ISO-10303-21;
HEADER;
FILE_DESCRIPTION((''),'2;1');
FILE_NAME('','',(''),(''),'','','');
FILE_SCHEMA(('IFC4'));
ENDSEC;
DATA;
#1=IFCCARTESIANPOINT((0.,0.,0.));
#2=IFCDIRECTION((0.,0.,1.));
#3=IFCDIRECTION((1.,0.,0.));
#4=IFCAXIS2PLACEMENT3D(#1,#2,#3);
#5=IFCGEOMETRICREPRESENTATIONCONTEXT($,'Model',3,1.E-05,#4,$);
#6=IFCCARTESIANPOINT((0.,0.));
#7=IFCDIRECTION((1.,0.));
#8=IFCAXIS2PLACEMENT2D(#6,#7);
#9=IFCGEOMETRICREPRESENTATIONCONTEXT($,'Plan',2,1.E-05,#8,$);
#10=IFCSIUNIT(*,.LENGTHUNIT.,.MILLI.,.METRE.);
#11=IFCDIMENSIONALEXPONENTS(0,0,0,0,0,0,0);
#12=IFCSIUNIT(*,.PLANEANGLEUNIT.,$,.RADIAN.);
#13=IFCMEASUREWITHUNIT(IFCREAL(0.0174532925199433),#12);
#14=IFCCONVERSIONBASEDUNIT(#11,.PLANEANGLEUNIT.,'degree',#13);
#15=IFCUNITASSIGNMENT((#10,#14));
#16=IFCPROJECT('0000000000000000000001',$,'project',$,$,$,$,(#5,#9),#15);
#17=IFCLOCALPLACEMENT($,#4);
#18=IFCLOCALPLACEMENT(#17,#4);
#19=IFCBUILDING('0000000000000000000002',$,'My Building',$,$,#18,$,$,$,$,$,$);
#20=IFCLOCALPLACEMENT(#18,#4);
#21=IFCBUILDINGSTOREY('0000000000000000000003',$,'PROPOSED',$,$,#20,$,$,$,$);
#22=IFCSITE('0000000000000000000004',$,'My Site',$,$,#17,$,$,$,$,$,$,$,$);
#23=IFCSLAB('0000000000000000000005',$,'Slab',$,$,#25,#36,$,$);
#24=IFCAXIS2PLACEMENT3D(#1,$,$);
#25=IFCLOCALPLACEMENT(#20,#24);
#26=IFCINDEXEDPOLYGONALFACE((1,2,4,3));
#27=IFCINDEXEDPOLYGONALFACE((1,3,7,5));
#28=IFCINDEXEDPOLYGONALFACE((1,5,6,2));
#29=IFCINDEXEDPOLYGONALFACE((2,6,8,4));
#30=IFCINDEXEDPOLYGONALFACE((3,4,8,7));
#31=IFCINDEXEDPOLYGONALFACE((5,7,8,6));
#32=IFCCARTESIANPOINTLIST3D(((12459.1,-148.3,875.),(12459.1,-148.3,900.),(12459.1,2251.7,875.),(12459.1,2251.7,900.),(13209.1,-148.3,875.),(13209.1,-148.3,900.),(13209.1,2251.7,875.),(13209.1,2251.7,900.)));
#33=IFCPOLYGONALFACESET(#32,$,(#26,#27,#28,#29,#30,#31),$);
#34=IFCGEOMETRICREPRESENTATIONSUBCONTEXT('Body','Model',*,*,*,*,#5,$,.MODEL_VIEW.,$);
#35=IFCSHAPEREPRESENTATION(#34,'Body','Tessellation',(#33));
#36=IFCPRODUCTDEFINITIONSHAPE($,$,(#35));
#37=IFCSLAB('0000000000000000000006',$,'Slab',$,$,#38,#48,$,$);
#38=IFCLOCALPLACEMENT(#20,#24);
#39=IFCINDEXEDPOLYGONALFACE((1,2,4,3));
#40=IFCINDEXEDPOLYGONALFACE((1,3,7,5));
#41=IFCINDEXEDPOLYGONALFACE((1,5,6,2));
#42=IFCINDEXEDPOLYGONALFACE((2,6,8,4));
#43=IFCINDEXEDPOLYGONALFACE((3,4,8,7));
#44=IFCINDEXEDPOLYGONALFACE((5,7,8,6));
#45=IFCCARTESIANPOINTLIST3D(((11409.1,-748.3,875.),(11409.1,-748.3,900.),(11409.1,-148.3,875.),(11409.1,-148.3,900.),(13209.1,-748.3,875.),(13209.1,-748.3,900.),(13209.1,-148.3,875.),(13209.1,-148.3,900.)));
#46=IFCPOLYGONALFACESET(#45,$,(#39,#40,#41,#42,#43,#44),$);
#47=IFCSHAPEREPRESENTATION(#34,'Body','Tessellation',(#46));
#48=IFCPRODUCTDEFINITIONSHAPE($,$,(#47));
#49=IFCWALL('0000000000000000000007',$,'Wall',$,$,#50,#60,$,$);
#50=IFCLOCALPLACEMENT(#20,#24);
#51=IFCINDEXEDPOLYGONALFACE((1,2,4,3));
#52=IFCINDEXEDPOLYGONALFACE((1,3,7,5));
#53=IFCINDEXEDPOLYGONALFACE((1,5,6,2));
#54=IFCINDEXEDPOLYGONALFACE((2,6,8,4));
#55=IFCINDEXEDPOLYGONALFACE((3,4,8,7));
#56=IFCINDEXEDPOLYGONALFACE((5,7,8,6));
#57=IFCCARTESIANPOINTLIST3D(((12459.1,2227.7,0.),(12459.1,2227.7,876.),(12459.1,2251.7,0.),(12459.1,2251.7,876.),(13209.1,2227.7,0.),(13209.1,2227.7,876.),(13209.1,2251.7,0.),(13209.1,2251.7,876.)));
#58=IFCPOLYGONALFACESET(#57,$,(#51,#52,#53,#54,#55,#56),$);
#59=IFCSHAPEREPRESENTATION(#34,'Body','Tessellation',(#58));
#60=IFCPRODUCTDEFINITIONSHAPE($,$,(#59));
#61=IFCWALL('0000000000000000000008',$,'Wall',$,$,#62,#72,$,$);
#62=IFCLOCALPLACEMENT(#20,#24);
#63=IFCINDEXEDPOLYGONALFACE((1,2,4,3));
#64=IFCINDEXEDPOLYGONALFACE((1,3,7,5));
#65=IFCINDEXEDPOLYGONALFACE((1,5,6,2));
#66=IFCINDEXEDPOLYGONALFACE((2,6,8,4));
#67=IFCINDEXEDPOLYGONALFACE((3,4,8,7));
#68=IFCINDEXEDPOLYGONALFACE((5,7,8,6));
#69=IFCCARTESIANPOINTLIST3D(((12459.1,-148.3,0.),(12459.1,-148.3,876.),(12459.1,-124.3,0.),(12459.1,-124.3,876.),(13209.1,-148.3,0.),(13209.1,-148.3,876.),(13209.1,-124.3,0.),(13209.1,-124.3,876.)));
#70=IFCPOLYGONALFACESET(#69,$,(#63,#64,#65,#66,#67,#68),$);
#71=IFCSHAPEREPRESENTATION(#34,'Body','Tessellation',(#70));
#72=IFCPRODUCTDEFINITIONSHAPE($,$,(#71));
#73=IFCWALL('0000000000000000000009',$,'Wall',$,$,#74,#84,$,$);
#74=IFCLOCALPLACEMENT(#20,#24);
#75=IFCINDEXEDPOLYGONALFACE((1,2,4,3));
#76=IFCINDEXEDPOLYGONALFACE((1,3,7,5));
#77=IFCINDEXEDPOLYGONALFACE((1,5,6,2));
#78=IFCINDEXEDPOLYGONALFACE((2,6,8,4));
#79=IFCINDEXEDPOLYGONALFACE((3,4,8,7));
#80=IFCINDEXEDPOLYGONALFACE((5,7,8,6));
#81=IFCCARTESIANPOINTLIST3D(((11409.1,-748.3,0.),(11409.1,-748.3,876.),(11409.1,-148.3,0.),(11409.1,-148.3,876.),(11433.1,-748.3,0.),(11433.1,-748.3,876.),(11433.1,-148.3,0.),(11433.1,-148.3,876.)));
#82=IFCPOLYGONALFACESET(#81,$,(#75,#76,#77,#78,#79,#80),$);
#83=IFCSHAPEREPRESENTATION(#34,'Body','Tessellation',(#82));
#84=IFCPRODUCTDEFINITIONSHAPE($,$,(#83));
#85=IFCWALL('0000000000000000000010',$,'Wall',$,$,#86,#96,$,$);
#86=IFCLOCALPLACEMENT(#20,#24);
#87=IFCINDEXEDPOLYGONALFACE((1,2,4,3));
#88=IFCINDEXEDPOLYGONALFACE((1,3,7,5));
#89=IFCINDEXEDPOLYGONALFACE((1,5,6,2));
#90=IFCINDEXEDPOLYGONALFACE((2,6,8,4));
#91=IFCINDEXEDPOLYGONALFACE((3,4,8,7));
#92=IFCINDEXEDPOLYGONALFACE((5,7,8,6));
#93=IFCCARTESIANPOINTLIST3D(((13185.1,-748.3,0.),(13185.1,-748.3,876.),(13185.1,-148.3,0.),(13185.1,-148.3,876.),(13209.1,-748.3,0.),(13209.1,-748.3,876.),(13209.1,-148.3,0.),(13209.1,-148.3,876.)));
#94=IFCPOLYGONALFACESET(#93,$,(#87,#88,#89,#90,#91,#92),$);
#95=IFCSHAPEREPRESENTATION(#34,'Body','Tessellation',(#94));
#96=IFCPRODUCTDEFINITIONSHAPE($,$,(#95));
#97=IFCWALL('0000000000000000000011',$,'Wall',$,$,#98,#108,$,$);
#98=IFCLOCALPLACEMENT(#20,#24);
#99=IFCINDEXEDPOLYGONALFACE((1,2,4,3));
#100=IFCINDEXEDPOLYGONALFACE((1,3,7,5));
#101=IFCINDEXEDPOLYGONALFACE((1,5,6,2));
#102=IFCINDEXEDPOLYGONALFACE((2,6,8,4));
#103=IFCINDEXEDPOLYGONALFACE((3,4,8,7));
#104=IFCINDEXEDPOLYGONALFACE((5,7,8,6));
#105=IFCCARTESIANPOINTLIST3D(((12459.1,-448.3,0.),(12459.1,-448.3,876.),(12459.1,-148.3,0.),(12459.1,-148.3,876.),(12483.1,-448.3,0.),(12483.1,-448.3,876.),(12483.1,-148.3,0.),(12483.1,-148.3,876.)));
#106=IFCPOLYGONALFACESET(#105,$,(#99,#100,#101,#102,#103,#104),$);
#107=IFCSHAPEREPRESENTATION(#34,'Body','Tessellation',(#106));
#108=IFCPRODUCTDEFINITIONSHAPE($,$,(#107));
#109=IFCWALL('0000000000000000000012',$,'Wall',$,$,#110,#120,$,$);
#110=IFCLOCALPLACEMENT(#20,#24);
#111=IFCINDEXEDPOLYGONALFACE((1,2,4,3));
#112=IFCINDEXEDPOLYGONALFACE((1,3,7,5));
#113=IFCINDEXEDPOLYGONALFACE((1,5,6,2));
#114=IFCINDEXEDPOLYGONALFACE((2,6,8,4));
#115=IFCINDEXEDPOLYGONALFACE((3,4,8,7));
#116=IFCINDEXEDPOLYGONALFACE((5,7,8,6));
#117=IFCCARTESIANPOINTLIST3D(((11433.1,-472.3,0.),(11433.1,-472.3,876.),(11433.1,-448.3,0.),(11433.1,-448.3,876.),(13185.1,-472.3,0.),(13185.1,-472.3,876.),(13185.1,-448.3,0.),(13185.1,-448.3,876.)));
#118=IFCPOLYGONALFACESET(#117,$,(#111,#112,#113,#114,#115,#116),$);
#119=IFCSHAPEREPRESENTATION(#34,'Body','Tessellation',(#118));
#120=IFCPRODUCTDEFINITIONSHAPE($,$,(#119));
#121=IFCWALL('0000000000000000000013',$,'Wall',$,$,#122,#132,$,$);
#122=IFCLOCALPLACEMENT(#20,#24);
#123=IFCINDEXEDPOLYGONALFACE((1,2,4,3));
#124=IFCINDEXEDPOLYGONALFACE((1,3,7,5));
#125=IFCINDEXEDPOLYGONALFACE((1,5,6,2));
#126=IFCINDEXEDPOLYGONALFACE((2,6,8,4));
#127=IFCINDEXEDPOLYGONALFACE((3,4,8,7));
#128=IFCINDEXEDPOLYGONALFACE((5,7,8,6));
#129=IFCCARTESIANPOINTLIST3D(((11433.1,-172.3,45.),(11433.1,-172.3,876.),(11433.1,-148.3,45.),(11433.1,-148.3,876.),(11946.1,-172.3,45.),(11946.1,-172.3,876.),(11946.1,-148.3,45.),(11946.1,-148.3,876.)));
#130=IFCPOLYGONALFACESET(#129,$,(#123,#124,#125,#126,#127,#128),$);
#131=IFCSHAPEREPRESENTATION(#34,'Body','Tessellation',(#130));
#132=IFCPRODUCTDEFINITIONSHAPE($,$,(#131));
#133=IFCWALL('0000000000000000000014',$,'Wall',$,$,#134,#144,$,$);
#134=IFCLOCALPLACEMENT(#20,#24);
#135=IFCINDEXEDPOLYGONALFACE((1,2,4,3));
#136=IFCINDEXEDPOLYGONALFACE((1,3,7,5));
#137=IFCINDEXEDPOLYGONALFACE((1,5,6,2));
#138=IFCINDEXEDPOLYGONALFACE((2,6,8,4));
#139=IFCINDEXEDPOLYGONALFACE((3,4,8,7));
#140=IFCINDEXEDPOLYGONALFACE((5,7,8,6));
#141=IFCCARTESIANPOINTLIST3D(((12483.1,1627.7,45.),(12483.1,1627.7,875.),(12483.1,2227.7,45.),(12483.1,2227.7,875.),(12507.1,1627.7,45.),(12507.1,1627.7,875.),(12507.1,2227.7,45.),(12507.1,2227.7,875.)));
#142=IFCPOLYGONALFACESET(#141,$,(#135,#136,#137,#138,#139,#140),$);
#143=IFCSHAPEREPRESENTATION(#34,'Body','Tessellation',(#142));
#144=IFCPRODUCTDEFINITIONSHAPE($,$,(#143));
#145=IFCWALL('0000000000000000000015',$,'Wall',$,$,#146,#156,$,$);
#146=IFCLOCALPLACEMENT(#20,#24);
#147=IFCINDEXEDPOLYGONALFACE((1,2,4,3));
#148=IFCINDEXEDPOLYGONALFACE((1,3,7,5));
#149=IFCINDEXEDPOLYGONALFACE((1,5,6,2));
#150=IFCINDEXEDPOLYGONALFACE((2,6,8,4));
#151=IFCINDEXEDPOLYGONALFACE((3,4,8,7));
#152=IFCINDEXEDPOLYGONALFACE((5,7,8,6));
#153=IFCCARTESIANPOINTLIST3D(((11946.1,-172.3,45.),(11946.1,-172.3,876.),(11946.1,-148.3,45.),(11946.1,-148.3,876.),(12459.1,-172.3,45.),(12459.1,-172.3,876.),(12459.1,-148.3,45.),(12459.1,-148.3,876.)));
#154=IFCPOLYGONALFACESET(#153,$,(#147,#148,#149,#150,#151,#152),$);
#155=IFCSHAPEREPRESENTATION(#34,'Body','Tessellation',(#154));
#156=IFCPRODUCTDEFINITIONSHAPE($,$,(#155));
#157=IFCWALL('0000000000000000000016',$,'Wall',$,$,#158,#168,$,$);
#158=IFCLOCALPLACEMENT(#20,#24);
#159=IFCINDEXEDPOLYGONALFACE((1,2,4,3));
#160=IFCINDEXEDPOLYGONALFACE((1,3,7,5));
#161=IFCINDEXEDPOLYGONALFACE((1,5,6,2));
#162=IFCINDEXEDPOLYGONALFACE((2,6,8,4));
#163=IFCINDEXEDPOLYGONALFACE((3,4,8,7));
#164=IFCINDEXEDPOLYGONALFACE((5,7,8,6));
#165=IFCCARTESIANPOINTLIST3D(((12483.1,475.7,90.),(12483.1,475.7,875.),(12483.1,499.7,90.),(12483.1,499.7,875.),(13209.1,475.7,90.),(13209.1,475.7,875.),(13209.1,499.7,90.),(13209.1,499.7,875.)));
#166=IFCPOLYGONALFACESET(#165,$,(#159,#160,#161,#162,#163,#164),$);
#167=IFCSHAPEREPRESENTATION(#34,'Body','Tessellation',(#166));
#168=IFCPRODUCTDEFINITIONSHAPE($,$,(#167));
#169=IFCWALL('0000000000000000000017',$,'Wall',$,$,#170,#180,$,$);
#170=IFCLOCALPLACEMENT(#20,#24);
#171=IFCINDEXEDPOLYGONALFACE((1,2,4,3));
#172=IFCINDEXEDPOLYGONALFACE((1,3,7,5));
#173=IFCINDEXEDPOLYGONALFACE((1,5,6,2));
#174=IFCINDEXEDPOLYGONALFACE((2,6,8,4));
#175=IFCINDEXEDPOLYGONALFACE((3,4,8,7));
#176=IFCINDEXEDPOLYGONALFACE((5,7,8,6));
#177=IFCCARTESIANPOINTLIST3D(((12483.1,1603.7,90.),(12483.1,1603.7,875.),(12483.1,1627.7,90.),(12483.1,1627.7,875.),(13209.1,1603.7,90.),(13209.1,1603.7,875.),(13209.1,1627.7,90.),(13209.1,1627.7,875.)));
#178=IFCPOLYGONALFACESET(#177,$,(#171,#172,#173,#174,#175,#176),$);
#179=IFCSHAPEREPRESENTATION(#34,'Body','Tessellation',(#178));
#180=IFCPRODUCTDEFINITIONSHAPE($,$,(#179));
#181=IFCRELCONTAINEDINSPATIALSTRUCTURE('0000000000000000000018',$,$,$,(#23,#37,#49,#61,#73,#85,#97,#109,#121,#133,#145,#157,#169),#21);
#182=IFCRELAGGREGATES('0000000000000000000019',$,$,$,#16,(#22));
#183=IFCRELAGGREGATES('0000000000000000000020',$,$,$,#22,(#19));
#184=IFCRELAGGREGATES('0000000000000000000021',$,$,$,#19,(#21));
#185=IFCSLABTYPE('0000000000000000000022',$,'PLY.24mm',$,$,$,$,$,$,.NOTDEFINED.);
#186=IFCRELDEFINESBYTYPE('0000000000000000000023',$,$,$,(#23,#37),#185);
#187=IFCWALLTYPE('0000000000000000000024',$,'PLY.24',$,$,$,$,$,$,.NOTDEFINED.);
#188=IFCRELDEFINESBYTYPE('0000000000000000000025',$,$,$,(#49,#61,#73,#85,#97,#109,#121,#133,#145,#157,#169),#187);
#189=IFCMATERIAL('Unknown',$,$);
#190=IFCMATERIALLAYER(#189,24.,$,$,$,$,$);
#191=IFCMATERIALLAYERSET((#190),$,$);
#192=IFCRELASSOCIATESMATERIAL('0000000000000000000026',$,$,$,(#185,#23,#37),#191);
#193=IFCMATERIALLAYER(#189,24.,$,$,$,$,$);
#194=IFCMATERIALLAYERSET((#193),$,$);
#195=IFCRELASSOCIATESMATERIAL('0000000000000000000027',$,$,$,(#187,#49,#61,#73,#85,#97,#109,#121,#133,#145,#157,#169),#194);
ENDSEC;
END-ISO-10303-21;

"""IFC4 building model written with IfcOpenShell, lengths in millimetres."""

from ifc_helpers import new_model, entity, si_unit, converted_unit, frame, origin_with_axes, origin_2d_with_axis, place, context, subcontext, project, spatial, line, indexed_curve, outline, extrude, material, layer, layer_set, layer_usage, type_object, element, save


model = new_model("IFC4")

# Units and contexts
model_context = context("Model", 3, precision=1e-05, world=origin_with_axes())
plan_context = context("Plan", 2, precision=1e-05, world=origin_2d_with_axis())
body_context = subcontext(model_context, "Body", "Model", "MODEL_VIEW")
ifc_project = project(units=[si_unit("LENGTHUNIT", "METRE", prefix="MILLI"), converted_unit("PLANEANGLEUNIT", "degree", entity("IfcReal", 0.0174532925199433), si_unit("PLANEANGLEUNIT", "RADIAN"), dimensions=[0, 0, 0, 0, 0, 0, 0])], contexts=[model_context, plan_context])

# Site, building, storey
site_placement = place(None, origin_with_axes())
site = spatial("IfcSite", under=ifc_project, at=site_placement, Name="My Site")
building_placement = place(site_placement, origin_with_axes())
building = spatial("IfcBuilding", under=site, at=building_placement, Name="My Building")
storey_placement = place(building_placement, origin_with_axes())
storey = spatial("IfcBuildingStorey", under=building, at=storey_placement, Name="PROPOSED")

# Slabs
ifc_material = material(Name="Unknown")
ifc_layer_1 = layer(ifc_material, 24.0)
ifc_layer_set_1 = layer_set([ifc_layer_1])
ifc_layer_usage_1 = layer_usage(ifc_layer_set_1, "AXIS3", "POSITIVE", 0.0)
slab_type = type_object("IfcSlabType", Name="PLY.24mm", PredefinedType="NOTDEFINED", material=ifc_layer_set_1)
slab_1_placement = place(storey_placement, frame((12459.1, -148.3, 875.0), z_axis=(0.0, 0.0, 1.0), x_axis=(1.0, 0.0, 0.0)))
element("IfcSlab", 1, at=slab_1_placement, inside=storey, type_object=slab_type, material=ifc_layer_usage_1, Name="Slab", context=body_context, shape_type="SweptSolid", body=[
    extrude(outline(indexed_curve([(750.0, 2400.0), (750.0, 0.0), (0.0, 0.0), (0.0, 2400.0)], segments=[line(4, 1), line(1, 2), line(2, 3), line(3, 4)], self_intersect=False)), None, (0.0, 0.0, 1.0), 25.0),
])
ifc_layer_usage_2 = layer_usage(ifc_layer_set_1, "AXIS3", "POSITIVE", 0.0)
slab_2_placement = place(storey_placement, frame((11409.1, -148.3, 875.0), z_axis=(0.0, 0.0, 1.0), x_axis=(0.0, -1.0, 0.0)))
element("IfcSlab", 2, at=slab_2_placement, inside=storey, type_object=slab_type, material=ifc_layer_usage_2, Name="Slab", context=body_context, shape_type="SweptSolid", body=[
    extrude(outline(indexed_curve([(600.0, 0.0), (600.0, 1800.0), (0.0, 1800.0), (0.0, 0.0)], segments=[line(3, 2), line(2, 1), line(1, 4), line(4, 3)], self_intersect=False)), None, (0.0, 0.0, 1.0), 25.0),
])

# Walls
ifc_layer_2 = layer(ifc_material, 24.0)
ifc_layer_set_2 = layer_set([ifc_layer_2])
ifc_layer_usage_3 = layer_usage(ifc_layer_set_2, "AXIS2", "POSITIVE", 0.0)
wall_type = type_object("IfcWallType", Name="PLY.24", PredefinedType="NOTDEFINED", material=ifc_layer_set_2)
wall_1_placement = place(storey_placement, frame((12459.1, 2227.7, 0.0), z_axis=(0.0, 0.0, 1.0), x_axis=(1.0, 0.0, 0.0)))
element("IfcWall", 3, at=wall_1_placement, inside=storey, type_object=wall_type, material=ifc_layer_usage_3, Name="Wall", context=body_context, shape_type="SweptSolid", body=[
    extrude(outline(indexed_curve([(0.0, 0.0), (0.0, 24.0), (750.0, 24.0), (750.0, 0.0), (0.0, 0.0)], self_intersect=False)), origin_with_axes(), (0.0, 0.0, 1.0), 876.0),
])
ifc_layer_usage_4 = layer_usage(ifc_layer_set_2, "AXIS2", "POSITIVE", 0.0)
wall_2_placement = place(storey_placement, frame((12459.1, -148.3, 0.0), z_axis=(0.0, 0.0, 1.0), x_axis=(1.0, 0.0, 0.0)))
element("IfcWall", 4, at=wall_2_placement, inside=storey, type_object=wall_type, material=ifc_layer_usage_4, Name="Wall", context=body_context, shape_type="SweptSolid", body=[
    extrude(outline(indexed_curve([(0.0, 0.0), (0.0, 24.0), (750.0, 24.0), (750.0, 0.0), (0.0, 0.0)], self_intersect=False)), origin_with_axes(), (0.0, 0.0, 1.0), 876.0),
])
ifc_layer_usage_5 = layer_usage(ifc_layer_set_2, "AXIS2", "POSITIVE", 0.0)
wall_3_placement = place(storey_placement, frame((11409.1, -148.3, 0.0), z_axis=(0.0, 0.0, 1.0), x_axis=(0.0, -1.0, 0.0)))
element("IfcWall", 5, at=wall_3_placement, inside=storey, type_object=wall_type, material=ifc_layer_usage_5, Name="Wall", context=body_context, shape_type="SweptSolid", body=[
    extrude(outline(indexed_curve([(0.0, 0.0), (0.0, 24.0), (600.0, 24.0), (600.0, 0.0), (0.0, 0.0)], self_intersect=False)), origin_with_axes(), (0.0, 0.0, 1.0), 876.0),
])
ifc_layer_usage_6 = layer_usage(ifc_layer_set_2, "AXIS2", "POSITIVE", 0.0)
wall_4_placement = place(storey_placement, frame((13185.1, -148.3, 0.0), z_axis=(0.0, 0.0, 1.0), x_axis=(0.0, -1.0, 0.0)))
element("IfcWall", 6, at=wall_4_placement, inside=storey, type_object=wall_type, material=ifc_layer_usage_6, Name="Wall", context=body_context, shape_type="SweptSolid", body=[
    extrude(outline(indexed_curve([(0.0, 0.0), (0.0, 24.0), (600.0, 24.0), (600.0, 0.0), (0.0, 0.0)], self_intersect=False)), origin_with_axes(), (0.0, 0.0, 1.0), 876.0),
])
ifc_layer_usage_7 = layer_usage(ifc_layer_set_2, "AXIS2", "POSITIVE", 0.0)
wall_5_placement = place(storey_placement, frame((12459.1, -148.3, 0.0), z_axis=(0.0, 0.0, 1.0), x_axis=(0.0, -1.0, 0.0)))
element("IfcWall", 7, at=wall_5_placement, inside=storey, type_object=wall_type, material=ifc_layer_usage_7, Name="Wall", context=body_context, shape_type="SweptSolid", body=[
    extrude(outline(indexed_curve([(0.0, 0.0), (0.0, 24.0), (300.0, 24.0), (300.0, 0.0), (0.0, 0.0)], self_intersect=False)), origin_with_axes(), (0.0, 0.0, 1.0), 876.0),
])
ifc_layer_usage_8 = layer_usage(ifc_layer_set_2, "AXIS2", "POSITIVE", 0.0)
wall_6_placement = place(storey_placement, frame((11433.1, -472.3, 0.0), z_axis=(0.0, 0.0, 1.0), x_axis=(1.0, 0.0, 0.0)))
element("IfcWall", 8, at=wall_6_placement, inside=storey, type_object=wall_type, material=ifc_layer_usage_8, Name="Wall", context=body_context, shape_type="SweptSolid", body=[
    extrude(outline(indexed_curve([(0.0, 0.0), (0.0, 24.0), (1752.0, 24.0), (1752.0, 0.0), (0.0, 0.0)], self_intersect=False)), origin_with_axes(), (0.0, 0.0, 1.0), 876.0),
])
ifc_layer_usage_9 = layer_usage(ifc_layer_set_2, "AXIS2", "POSITIVE", 0.0)
wall_7_placement = place(storey_placement, frame((11433.1, -172.3, 45.0), z_axis=(0.0, 0.0, 1.0), x_axis=(1.0, 0.0, 0.0)))
element("IfcWall", 9, at=wall_7_placement, inside=storey, type_object=wall_type, material=ifc_layer_usage_9, Name="Wall", context=body_context, shape_type="SweptSolid", body=[
    extrude(outline(indexed_curve([(0.0, 0.0), (0.0, 24.0), (513.0, 24.0), (513.0, 0.0), (0.0, 0.0)], self_intersect=False)), origin_with_axes(), (0.0, 0.0, 1.0), 831.0),
])
ifc_layer_usage_10 = layer_usage(ifc_layer_set_2, "AXIS2", "POSITIVE", 0.0)
wall_8_placement = place(storey_placement, frame((12483.1, 2227.7, 45.0), z_axis=(0.0, 0.0, 1.0), x_axis=(0.0, -1.0, 0.0)))
element("IfcWall", 10, at=wall_8_placement, inside=storey, type_object=wall_type, material=ifc_layer_usage_10, Name="Wall", context=body_context, shape_type="SweptSolid", body=[
    extrude(outline(indexed_curve([(0.0, 0.0), (0.0, 24.0), (600.0, 24.0), (600.0, 0.0), (0.0, 0.0)], self_intersect=False)), origin_with_axes(), (0.0, 0.0, 1.0), 830.0),
])
ifc_layer_usage_11 = layer_usage(ifc_layer_set_2, "AXIS2", "POSITIVE", 0.0)
wall_9_placement = place(storey_placement, frame((11946.1, -172.3, 45.0), z_axis=(0.0, 0.0, 1.0), x_axis=(1.0, 0.0, 0.0)))
element("IfcWall", 11, at=wall_9_placement, inside=storey, type_object=wall_type, material=ifc_layer_usage_11, Name="Wall", context=body_context, shape_type="SweptSolid", body=[
    extrude(outline(indexed_curve([(0.0, 0.0), (0.0, 24.0), (513.0, 24.0), (513.0, 0.0), (0.0, 0.0)], self_intersect=False)), origin_with_axes(), (0.0, 0.0, 1.0), 831.0),
])
ifc_layer_usage_12 = layer_usage(ifc_layer_set_2, "AXIS2", "POSITIVE", 0.0)
wall_10_placement = place(storey_placement, frame((12483.1, 475.7, 90.0), z_axis=(0.0, 0.0, 1.0), x_axis=(1.0, 0.0, 0.0)))
element("IfcWall", 12, at=wall_10_placement, inside=storey, type_object=wall_type, material=ifc_layer_usage_12, Name="Wall", context=body_context, shape_type="SweptSolid", body=[
    extrude(outline(indexed_curve([(0.0, 0.0), (0.0, 24.0), (726.0, 24.0), (726.0, 0.0), (0.0, 0.0)], self_intersect=False)), origin_with_axes(), (0.0, 0.0, 1.0), 785.0),
])
ifc_layer_usage_13 = layer_usage(ifc_layer_set_2, "AXIS2", "POSITIVE", 0.0)
wall_11_placement = place(storey_placement, frame((12483.1, 1603.7, 90.0), z_axis=(0.0, 0.0, 1.0), x_axis=(1.0, 0.0, 0.0)))
element("IfcWall", 13, at=wall_11_placement, inside=storey, type_object=wall_type, material=ifc_layer_usage_13, Name="Wall", context=body_context, shape_type="SweptSolid", body=[
    extrude(outline(indexed_curve([(0.0, 0.0), (0.0, 24.0), (726.0, 24.0), (726.0, 0.0), (0.0, 0.0)], self_intersect=False)), origin_with_axes(), (0.0, 0.0, 1.0), 785.0),
])

save(model, "model.ifc")
